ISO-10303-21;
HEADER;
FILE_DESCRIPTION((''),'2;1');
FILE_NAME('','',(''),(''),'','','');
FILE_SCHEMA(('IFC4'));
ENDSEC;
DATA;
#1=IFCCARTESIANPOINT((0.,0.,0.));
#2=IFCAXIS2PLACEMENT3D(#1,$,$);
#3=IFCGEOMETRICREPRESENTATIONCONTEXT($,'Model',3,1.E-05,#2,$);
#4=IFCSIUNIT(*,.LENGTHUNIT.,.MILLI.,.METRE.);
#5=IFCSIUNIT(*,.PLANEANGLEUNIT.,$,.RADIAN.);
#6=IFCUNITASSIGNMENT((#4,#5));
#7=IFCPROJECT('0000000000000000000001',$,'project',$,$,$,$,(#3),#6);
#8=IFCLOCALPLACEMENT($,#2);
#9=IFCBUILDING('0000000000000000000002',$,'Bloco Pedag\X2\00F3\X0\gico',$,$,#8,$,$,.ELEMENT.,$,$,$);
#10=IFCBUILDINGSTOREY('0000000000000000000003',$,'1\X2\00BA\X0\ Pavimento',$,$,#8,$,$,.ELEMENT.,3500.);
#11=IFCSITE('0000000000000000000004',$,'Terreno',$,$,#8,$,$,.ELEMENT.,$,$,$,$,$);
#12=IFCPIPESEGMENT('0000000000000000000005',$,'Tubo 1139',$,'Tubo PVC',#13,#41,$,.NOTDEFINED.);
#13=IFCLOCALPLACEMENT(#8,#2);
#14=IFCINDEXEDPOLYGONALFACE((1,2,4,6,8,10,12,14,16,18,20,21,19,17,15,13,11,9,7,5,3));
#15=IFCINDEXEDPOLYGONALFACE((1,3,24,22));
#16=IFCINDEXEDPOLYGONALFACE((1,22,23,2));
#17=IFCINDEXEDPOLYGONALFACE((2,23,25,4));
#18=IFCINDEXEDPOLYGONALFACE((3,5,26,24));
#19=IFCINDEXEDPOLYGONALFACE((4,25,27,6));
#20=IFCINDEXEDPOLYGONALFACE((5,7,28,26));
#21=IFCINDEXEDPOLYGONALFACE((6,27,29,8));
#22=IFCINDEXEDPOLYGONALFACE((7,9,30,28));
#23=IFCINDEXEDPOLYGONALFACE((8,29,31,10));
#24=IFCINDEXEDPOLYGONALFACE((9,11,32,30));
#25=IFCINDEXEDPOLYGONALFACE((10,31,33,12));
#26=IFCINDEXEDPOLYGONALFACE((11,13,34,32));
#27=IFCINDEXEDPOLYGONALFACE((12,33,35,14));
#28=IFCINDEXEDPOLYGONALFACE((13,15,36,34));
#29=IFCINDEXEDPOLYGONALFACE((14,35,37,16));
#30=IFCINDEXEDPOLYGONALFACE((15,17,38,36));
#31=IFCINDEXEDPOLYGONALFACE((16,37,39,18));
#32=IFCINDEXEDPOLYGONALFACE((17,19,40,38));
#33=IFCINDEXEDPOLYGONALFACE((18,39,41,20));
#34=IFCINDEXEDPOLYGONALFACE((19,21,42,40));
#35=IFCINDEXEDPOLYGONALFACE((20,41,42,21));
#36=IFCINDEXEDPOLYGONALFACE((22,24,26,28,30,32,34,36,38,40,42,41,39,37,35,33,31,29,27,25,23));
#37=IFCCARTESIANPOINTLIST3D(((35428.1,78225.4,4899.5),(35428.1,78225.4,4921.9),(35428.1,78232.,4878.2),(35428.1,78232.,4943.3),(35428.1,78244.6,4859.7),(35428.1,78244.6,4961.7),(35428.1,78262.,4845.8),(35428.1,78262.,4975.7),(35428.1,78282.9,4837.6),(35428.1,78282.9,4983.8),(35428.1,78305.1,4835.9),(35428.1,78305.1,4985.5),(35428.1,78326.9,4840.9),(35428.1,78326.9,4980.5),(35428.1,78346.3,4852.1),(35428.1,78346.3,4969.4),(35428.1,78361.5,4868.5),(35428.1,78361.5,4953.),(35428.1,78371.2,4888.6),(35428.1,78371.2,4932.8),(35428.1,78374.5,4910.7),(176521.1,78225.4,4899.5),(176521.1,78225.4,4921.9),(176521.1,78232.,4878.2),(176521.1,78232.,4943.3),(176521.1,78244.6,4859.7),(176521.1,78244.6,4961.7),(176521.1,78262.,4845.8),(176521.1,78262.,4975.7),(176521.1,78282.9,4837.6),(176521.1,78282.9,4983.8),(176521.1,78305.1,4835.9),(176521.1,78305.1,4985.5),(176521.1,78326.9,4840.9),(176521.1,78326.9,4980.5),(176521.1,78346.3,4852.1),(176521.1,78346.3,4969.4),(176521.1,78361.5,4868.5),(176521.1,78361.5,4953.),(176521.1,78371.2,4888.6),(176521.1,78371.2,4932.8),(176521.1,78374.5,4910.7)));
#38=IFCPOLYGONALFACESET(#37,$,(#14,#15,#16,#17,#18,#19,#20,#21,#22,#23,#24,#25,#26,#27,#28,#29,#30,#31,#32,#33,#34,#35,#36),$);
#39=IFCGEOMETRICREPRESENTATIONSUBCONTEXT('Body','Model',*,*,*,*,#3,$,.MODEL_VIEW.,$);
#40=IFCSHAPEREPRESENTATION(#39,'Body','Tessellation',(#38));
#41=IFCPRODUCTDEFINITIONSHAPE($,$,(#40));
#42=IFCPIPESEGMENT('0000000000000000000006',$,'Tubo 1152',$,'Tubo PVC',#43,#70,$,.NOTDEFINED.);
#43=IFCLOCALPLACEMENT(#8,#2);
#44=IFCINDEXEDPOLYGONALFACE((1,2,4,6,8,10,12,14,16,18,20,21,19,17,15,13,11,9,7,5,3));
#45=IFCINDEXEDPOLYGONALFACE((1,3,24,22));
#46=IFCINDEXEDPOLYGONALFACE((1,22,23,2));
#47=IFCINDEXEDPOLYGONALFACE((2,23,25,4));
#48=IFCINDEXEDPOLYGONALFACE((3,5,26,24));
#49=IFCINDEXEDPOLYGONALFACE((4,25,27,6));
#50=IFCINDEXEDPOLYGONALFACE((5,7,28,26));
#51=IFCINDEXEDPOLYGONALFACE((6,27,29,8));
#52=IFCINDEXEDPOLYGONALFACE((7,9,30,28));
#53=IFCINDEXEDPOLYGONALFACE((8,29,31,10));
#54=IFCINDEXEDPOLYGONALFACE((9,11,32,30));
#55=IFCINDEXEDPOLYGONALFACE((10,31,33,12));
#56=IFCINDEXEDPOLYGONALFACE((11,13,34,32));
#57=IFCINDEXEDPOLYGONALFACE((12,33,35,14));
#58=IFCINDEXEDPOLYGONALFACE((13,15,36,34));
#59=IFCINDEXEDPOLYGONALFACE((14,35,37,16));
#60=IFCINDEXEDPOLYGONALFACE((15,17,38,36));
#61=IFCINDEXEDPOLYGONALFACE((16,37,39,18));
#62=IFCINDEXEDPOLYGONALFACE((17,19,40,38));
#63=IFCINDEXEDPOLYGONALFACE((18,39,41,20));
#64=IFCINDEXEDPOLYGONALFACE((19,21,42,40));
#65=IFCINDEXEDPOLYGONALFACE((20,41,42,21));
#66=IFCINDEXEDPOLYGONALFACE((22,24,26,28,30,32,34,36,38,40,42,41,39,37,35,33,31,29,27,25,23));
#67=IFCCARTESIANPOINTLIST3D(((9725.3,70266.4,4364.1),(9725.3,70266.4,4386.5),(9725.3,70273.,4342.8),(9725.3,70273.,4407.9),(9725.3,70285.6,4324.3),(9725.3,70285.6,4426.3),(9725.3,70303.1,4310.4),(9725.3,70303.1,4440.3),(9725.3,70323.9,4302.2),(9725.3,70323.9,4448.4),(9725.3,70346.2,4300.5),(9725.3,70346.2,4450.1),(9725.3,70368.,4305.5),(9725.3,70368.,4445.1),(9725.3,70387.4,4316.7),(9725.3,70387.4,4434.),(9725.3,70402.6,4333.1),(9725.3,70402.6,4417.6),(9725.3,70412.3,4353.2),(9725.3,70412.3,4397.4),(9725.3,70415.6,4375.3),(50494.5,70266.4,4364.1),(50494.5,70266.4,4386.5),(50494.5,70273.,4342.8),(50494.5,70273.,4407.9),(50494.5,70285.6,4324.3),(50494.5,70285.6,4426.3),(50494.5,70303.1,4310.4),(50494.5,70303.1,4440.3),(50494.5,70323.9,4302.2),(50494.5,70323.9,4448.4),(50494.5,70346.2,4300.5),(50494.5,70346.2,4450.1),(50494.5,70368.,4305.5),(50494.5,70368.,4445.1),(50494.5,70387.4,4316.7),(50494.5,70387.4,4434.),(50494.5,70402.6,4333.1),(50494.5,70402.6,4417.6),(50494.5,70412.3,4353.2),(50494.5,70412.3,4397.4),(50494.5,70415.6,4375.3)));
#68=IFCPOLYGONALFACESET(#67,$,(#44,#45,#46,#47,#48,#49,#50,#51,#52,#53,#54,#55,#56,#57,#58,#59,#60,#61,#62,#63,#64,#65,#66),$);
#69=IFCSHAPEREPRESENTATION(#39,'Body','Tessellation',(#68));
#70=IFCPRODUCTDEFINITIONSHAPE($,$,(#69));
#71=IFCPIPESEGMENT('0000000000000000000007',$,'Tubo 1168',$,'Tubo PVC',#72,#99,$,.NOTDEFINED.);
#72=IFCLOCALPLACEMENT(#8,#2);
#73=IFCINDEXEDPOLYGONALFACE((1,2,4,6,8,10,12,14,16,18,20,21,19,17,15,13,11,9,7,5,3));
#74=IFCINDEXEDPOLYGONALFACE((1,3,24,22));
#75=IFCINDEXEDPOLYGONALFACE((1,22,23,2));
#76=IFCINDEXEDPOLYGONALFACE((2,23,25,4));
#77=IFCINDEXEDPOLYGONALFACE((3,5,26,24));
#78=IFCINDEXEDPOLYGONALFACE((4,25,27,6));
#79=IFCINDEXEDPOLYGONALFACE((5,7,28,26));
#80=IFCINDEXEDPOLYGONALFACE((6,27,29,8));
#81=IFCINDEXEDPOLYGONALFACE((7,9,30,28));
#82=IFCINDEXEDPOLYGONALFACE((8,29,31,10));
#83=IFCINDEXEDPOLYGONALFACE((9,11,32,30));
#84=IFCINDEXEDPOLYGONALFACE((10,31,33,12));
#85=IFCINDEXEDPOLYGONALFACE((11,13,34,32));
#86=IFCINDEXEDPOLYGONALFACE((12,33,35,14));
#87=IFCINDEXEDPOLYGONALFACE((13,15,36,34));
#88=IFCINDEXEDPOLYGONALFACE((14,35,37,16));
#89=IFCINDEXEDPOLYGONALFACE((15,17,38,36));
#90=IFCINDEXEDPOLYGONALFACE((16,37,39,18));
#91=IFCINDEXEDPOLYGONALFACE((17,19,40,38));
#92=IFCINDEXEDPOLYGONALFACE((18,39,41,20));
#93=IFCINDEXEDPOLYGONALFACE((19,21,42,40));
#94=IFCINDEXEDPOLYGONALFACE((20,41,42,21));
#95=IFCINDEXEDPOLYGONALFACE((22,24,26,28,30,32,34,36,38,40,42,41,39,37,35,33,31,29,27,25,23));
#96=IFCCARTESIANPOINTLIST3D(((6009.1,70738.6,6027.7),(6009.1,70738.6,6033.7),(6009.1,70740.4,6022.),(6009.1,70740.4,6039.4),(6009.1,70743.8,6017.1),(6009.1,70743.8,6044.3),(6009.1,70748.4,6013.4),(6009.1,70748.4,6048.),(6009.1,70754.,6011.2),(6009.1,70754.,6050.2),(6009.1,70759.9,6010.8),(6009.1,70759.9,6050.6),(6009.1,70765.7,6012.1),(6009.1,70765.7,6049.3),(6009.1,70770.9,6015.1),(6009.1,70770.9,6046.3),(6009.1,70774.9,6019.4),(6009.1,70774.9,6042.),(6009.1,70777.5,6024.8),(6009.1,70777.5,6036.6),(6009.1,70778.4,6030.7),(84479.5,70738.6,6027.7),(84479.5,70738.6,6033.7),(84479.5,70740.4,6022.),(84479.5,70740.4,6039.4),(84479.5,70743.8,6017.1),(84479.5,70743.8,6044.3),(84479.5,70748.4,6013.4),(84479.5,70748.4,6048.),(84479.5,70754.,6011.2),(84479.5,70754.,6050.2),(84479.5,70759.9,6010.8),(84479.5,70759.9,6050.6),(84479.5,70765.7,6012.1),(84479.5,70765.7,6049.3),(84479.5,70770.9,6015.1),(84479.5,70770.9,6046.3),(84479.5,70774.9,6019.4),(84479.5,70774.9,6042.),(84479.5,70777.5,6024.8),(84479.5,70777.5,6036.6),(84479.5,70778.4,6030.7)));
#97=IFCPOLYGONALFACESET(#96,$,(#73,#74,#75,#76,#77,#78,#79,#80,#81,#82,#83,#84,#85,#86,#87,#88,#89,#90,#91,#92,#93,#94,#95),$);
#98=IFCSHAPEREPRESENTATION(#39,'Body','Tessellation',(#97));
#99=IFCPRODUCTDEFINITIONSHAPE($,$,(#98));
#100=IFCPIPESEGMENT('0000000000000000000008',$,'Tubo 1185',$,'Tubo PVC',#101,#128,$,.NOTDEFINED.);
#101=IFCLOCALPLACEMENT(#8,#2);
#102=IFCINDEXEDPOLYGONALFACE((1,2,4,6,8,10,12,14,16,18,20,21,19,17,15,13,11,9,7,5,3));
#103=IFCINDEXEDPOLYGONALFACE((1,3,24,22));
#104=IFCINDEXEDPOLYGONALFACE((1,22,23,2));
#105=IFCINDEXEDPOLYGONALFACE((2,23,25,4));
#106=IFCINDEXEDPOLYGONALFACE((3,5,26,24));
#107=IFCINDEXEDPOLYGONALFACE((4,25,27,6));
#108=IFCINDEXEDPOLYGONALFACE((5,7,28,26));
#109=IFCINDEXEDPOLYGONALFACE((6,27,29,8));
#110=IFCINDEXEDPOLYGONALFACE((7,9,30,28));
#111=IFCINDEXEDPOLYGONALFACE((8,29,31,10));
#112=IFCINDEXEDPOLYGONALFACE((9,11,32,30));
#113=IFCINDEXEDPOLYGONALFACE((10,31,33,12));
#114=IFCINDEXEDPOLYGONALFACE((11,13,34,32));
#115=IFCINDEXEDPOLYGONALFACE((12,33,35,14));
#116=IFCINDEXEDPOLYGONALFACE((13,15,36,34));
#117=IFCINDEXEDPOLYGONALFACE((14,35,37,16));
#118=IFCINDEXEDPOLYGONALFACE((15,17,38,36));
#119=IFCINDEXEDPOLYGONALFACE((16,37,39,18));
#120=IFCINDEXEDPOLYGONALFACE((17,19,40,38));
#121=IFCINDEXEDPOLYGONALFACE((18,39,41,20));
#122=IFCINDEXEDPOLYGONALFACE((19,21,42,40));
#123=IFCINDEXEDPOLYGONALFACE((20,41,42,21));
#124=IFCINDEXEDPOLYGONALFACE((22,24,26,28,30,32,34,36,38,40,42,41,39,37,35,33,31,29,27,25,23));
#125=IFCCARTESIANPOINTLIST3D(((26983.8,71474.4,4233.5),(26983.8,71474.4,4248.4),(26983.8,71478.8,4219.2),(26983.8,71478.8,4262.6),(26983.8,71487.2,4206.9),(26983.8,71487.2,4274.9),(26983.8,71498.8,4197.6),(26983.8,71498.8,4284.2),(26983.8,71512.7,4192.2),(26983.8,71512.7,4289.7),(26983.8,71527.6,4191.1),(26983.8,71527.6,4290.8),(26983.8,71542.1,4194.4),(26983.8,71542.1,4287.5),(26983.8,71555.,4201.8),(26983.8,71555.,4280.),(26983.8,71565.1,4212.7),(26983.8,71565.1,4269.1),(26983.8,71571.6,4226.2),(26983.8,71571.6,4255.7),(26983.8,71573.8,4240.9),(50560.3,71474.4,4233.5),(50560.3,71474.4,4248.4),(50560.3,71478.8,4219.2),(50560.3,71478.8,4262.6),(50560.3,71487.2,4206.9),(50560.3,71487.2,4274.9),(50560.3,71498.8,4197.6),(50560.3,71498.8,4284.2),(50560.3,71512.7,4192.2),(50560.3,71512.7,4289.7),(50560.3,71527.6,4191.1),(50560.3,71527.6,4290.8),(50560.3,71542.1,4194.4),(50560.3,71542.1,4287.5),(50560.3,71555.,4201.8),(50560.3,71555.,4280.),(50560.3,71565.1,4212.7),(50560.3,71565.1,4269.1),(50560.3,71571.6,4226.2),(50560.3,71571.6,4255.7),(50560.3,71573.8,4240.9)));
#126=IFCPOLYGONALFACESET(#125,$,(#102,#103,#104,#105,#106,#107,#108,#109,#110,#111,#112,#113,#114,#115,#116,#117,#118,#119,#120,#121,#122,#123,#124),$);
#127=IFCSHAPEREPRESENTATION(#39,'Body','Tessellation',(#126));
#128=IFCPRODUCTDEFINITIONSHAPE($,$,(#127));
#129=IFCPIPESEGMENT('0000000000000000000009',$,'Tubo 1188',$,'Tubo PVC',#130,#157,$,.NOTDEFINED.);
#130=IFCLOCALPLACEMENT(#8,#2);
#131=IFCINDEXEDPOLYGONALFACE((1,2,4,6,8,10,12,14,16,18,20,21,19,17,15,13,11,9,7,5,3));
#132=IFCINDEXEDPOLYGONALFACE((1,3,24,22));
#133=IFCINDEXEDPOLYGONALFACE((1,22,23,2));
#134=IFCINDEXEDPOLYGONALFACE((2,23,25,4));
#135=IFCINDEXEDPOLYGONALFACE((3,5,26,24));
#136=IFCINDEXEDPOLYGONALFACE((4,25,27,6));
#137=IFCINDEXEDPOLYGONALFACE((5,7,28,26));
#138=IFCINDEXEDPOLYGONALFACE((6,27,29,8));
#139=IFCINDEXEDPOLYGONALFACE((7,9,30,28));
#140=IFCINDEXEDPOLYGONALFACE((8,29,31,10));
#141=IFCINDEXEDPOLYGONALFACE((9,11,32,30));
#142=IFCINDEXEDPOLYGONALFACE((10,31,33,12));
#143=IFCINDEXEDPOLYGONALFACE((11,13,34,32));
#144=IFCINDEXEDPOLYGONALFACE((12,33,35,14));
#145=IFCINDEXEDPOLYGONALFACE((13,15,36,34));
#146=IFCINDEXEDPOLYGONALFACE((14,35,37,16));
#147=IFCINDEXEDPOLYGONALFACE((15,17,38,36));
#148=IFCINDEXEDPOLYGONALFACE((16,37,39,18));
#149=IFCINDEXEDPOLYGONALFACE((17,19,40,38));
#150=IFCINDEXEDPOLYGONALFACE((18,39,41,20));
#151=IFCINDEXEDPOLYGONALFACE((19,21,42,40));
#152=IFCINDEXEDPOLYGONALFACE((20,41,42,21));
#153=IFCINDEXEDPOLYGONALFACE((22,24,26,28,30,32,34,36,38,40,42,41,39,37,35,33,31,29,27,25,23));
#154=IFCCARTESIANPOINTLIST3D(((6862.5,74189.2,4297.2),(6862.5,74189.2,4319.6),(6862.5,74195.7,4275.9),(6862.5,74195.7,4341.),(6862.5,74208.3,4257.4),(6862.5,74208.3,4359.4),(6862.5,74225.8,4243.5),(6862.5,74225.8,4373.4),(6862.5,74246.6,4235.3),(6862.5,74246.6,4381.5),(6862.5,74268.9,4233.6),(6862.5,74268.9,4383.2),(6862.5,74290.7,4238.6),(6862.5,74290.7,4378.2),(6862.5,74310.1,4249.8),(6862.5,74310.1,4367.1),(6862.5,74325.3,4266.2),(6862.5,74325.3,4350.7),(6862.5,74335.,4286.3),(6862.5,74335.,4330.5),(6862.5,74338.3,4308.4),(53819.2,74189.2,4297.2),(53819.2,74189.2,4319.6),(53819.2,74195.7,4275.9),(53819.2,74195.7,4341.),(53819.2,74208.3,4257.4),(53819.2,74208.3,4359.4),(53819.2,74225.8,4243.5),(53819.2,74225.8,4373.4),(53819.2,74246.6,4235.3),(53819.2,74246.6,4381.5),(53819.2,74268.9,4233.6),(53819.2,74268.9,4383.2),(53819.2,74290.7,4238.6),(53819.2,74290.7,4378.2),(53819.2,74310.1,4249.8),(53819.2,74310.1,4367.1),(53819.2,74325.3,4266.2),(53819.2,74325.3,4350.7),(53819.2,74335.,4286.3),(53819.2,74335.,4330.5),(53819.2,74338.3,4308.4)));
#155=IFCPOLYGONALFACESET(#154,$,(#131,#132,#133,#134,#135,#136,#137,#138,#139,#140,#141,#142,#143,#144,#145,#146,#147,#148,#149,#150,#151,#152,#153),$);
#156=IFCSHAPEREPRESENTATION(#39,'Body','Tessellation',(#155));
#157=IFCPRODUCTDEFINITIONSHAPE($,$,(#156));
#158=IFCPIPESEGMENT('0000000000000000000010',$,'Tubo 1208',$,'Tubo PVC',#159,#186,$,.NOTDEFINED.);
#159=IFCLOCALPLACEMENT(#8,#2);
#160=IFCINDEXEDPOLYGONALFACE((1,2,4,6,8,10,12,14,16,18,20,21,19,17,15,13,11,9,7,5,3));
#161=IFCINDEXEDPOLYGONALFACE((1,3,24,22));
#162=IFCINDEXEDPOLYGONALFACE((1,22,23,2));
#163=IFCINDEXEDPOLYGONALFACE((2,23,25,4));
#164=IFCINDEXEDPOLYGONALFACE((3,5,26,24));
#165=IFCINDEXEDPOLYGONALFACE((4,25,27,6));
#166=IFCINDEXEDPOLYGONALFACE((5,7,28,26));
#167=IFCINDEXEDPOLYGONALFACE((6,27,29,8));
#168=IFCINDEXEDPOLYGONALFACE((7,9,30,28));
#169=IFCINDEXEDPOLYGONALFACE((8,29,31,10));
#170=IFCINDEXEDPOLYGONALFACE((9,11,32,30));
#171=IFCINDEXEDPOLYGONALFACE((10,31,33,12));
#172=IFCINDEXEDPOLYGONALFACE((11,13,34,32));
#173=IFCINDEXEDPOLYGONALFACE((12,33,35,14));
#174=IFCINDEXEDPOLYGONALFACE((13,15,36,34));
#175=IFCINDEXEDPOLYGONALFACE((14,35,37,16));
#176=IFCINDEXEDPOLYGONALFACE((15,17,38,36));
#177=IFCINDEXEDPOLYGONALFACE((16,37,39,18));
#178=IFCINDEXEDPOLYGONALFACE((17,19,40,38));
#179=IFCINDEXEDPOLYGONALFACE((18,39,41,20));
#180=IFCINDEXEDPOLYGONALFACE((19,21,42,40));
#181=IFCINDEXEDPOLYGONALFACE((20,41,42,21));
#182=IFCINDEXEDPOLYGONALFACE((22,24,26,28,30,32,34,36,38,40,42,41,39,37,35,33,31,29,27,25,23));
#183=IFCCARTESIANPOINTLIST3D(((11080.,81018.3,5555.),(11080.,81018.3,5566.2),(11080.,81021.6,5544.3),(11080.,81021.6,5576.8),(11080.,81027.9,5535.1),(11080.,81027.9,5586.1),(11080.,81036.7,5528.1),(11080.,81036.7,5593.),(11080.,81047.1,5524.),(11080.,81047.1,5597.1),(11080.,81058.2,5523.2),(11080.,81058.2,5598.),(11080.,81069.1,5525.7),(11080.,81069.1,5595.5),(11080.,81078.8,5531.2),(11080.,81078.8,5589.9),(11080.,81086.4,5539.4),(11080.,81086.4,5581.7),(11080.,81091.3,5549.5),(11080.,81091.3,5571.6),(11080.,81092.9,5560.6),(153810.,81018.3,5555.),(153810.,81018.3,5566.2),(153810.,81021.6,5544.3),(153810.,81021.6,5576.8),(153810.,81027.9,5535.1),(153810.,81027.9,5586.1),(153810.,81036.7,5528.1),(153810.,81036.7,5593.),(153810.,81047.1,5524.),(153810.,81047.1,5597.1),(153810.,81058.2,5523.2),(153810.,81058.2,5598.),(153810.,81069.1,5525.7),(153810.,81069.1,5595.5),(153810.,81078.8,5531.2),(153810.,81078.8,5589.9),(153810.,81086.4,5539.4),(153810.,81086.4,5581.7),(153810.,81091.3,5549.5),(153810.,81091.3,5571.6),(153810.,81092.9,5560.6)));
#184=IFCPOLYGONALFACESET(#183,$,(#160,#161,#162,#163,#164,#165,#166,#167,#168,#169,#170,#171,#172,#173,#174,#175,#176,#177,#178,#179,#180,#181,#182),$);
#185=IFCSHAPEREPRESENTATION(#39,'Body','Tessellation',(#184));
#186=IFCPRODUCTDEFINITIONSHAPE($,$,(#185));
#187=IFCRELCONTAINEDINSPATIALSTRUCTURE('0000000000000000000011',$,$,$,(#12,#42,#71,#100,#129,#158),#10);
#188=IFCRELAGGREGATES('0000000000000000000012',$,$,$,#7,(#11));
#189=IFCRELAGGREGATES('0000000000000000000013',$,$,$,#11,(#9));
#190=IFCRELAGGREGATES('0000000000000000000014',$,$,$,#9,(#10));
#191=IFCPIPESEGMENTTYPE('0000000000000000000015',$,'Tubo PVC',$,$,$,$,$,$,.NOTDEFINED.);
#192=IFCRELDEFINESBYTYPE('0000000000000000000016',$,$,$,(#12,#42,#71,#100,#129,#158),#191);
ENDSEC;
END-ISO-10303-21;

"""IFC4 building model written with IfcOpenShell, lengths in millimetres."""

from ifc_helpers import new_model, si_unit, frame, origin, origin_2d, place, context, subcontext, project, spatial, circle, extrude, type_object, element, save


model = new_model("IFC4")

# Units and contexts
model_context = context("Model", 3, precision=1e-05, world=origin())
body_context = subcontext(model_context, "Body", "Model", "MODEL_VIEW")
ifc_project = project(units=[si_unit("LENGTHUNIT", "METRE", prefix="MILLI"), si_unit("PLANEANGLEUNIT", "RADIAN")], contexts=[model_context])

# Site, building, storey
placement = place(None, origin())
site = spatial("IfcSite", under=ifc_project, at=placement, Name="Terreno", CompositionType="ELEMENT")
building = spatial("IfcBuilding", under=site, at=placement, Name="Bloco Pedagógico", CompositionType="ELEMENT")
storey = spatial("IfcBuildingStorey", under=building, at=placement, Name="1º Pavimento", CompositionType="ELEMENT", Elevation=3500.0)

# Pipe segments
pipe_segment_type = type_object("IfcPipeSegmentType", Name="Tubo PVC", PredefinedType="NOTDEFINED")
pipe_segment_1_placement = place(None, frame((35428.1, 78299.5, 4910.7), z_axis=(1.0, 0.0, 0.0), x_axis=(0.0, 1.0, 0.0)))
element("IfcPipeSegment", 1, at=pipe_segment_1_placement, inside=storey, type_object=pipe_segment_type, Name="Tubo 1139", ObjectType="Tubo PVC", PredefinedType="NOTDEFINED", context=body_context, shape_type="SweptSolid", body=[
    extrude(circle(Radius=75.0, at=origin_2d()), None, (0.0, 0.0, 1.0), 141092.9),
])
pipe_segment_2_placement = place(None, frame((9725.3, 70340.6, 4375.3), z_axis=(1.0, 0.0, 0.0), x_axis=(0.0, 1.0, 0.0)))
element("IfcPipeSegment", 2, at=pipe_segment_2_placement, inside=storey, type_object=pipe_segment_type, Name="Tubo 1152", ObjectType="Tubo PVC", PredefinedType="NOTDEFINED", context=body_context, shape_type="SweptSolid", body=[
    extrude(circle(Radius=75.0, at=origin_2d()), None, (0.0, 0.0, 1.0), 40769.1),
])
pipe_segment_3_placement = place(None, frame((6009.1, 70758.4, 6030.7), z_axis=(1.0, 0.0, 0.0), x_axis=(0.0, 1.0, 0.0)))
element("IfcPipeSegment", 3, at=pipe_segment_3_placement, inside=storey, type_object=pipe_segment_type, Name="Tubo 1168", ObjectType="Tubo PVC", PredefinedType="NOTDEFINED", context=body_context, shape_type="SweptSolid", body=[
    extrude(circle(Radius=20.0, at=origin_2d()), None, (0.0, 0.0, 1.0), 78470.4),
])
pipe_segment_4_placement = place(None, frame((26983.8, 71523.8, 4240.9), z_axis=(1.0, 0.0, 0.0), x_axis=(0.0, 1.0, 0.0)))
element("IfcPipeSegment", 4, at=pipe_segment_4_placement, inside=storey, type_object=pipe_segment_type, Name="Tubo 1185", ObjectType="Tubo PVC", PredefinedType="NOTDEFINED", context=body_context, shape_type="SweptSolid", body=[
    extrude(circle(Radius=50.0, at=origin_2d()), None, (0.0, 0.0, 1.0), 23576.4),
])
pipe_segment_5_placement = place(None, frame((6862.5, 74263.3, 4308.4), z_axis=(1.0, 0.0, 0.0), x_axis=(0.0, 1.0, 0.0)))
element("IfcPipeSegment", 5, at=pipe_segment_5_placement, inside=storey, type_object=pipe_segment_type, Name="Tubo 1188", ObjectType="Tubo PVC", PredefinedType="NOTDEFINED", context=body_context, shape_type="SweptSolid", body=[
    extrude(circle(Radius=75.0, at=origin_2d()), None, (0.0, 0.0, 1.0), 46956.8),
])
pipe_segment_6_placement = place(None, frame((11080.0, 81055.4, 5560.6), z_axis=(1.0, 0.0, 0.0), x_axis=(0.0, 1.0, 0.0)))
element("IfcPipeSegment", 6, at=pipe_segment_6_placement, inside=storey, type_object=pipe_segment_type, Name="Tubo 1208", ObjectType="Tubo PVC", PredefinedType="NOTDEFINED", context=body_context, shape_type="SweptSolid", body=[
    extrude(circle(Radius=37.5, at=origin_2d()), None, (0.0, 0.0, 1.0), 142730.0),
])

save(model, "model.ifc")
